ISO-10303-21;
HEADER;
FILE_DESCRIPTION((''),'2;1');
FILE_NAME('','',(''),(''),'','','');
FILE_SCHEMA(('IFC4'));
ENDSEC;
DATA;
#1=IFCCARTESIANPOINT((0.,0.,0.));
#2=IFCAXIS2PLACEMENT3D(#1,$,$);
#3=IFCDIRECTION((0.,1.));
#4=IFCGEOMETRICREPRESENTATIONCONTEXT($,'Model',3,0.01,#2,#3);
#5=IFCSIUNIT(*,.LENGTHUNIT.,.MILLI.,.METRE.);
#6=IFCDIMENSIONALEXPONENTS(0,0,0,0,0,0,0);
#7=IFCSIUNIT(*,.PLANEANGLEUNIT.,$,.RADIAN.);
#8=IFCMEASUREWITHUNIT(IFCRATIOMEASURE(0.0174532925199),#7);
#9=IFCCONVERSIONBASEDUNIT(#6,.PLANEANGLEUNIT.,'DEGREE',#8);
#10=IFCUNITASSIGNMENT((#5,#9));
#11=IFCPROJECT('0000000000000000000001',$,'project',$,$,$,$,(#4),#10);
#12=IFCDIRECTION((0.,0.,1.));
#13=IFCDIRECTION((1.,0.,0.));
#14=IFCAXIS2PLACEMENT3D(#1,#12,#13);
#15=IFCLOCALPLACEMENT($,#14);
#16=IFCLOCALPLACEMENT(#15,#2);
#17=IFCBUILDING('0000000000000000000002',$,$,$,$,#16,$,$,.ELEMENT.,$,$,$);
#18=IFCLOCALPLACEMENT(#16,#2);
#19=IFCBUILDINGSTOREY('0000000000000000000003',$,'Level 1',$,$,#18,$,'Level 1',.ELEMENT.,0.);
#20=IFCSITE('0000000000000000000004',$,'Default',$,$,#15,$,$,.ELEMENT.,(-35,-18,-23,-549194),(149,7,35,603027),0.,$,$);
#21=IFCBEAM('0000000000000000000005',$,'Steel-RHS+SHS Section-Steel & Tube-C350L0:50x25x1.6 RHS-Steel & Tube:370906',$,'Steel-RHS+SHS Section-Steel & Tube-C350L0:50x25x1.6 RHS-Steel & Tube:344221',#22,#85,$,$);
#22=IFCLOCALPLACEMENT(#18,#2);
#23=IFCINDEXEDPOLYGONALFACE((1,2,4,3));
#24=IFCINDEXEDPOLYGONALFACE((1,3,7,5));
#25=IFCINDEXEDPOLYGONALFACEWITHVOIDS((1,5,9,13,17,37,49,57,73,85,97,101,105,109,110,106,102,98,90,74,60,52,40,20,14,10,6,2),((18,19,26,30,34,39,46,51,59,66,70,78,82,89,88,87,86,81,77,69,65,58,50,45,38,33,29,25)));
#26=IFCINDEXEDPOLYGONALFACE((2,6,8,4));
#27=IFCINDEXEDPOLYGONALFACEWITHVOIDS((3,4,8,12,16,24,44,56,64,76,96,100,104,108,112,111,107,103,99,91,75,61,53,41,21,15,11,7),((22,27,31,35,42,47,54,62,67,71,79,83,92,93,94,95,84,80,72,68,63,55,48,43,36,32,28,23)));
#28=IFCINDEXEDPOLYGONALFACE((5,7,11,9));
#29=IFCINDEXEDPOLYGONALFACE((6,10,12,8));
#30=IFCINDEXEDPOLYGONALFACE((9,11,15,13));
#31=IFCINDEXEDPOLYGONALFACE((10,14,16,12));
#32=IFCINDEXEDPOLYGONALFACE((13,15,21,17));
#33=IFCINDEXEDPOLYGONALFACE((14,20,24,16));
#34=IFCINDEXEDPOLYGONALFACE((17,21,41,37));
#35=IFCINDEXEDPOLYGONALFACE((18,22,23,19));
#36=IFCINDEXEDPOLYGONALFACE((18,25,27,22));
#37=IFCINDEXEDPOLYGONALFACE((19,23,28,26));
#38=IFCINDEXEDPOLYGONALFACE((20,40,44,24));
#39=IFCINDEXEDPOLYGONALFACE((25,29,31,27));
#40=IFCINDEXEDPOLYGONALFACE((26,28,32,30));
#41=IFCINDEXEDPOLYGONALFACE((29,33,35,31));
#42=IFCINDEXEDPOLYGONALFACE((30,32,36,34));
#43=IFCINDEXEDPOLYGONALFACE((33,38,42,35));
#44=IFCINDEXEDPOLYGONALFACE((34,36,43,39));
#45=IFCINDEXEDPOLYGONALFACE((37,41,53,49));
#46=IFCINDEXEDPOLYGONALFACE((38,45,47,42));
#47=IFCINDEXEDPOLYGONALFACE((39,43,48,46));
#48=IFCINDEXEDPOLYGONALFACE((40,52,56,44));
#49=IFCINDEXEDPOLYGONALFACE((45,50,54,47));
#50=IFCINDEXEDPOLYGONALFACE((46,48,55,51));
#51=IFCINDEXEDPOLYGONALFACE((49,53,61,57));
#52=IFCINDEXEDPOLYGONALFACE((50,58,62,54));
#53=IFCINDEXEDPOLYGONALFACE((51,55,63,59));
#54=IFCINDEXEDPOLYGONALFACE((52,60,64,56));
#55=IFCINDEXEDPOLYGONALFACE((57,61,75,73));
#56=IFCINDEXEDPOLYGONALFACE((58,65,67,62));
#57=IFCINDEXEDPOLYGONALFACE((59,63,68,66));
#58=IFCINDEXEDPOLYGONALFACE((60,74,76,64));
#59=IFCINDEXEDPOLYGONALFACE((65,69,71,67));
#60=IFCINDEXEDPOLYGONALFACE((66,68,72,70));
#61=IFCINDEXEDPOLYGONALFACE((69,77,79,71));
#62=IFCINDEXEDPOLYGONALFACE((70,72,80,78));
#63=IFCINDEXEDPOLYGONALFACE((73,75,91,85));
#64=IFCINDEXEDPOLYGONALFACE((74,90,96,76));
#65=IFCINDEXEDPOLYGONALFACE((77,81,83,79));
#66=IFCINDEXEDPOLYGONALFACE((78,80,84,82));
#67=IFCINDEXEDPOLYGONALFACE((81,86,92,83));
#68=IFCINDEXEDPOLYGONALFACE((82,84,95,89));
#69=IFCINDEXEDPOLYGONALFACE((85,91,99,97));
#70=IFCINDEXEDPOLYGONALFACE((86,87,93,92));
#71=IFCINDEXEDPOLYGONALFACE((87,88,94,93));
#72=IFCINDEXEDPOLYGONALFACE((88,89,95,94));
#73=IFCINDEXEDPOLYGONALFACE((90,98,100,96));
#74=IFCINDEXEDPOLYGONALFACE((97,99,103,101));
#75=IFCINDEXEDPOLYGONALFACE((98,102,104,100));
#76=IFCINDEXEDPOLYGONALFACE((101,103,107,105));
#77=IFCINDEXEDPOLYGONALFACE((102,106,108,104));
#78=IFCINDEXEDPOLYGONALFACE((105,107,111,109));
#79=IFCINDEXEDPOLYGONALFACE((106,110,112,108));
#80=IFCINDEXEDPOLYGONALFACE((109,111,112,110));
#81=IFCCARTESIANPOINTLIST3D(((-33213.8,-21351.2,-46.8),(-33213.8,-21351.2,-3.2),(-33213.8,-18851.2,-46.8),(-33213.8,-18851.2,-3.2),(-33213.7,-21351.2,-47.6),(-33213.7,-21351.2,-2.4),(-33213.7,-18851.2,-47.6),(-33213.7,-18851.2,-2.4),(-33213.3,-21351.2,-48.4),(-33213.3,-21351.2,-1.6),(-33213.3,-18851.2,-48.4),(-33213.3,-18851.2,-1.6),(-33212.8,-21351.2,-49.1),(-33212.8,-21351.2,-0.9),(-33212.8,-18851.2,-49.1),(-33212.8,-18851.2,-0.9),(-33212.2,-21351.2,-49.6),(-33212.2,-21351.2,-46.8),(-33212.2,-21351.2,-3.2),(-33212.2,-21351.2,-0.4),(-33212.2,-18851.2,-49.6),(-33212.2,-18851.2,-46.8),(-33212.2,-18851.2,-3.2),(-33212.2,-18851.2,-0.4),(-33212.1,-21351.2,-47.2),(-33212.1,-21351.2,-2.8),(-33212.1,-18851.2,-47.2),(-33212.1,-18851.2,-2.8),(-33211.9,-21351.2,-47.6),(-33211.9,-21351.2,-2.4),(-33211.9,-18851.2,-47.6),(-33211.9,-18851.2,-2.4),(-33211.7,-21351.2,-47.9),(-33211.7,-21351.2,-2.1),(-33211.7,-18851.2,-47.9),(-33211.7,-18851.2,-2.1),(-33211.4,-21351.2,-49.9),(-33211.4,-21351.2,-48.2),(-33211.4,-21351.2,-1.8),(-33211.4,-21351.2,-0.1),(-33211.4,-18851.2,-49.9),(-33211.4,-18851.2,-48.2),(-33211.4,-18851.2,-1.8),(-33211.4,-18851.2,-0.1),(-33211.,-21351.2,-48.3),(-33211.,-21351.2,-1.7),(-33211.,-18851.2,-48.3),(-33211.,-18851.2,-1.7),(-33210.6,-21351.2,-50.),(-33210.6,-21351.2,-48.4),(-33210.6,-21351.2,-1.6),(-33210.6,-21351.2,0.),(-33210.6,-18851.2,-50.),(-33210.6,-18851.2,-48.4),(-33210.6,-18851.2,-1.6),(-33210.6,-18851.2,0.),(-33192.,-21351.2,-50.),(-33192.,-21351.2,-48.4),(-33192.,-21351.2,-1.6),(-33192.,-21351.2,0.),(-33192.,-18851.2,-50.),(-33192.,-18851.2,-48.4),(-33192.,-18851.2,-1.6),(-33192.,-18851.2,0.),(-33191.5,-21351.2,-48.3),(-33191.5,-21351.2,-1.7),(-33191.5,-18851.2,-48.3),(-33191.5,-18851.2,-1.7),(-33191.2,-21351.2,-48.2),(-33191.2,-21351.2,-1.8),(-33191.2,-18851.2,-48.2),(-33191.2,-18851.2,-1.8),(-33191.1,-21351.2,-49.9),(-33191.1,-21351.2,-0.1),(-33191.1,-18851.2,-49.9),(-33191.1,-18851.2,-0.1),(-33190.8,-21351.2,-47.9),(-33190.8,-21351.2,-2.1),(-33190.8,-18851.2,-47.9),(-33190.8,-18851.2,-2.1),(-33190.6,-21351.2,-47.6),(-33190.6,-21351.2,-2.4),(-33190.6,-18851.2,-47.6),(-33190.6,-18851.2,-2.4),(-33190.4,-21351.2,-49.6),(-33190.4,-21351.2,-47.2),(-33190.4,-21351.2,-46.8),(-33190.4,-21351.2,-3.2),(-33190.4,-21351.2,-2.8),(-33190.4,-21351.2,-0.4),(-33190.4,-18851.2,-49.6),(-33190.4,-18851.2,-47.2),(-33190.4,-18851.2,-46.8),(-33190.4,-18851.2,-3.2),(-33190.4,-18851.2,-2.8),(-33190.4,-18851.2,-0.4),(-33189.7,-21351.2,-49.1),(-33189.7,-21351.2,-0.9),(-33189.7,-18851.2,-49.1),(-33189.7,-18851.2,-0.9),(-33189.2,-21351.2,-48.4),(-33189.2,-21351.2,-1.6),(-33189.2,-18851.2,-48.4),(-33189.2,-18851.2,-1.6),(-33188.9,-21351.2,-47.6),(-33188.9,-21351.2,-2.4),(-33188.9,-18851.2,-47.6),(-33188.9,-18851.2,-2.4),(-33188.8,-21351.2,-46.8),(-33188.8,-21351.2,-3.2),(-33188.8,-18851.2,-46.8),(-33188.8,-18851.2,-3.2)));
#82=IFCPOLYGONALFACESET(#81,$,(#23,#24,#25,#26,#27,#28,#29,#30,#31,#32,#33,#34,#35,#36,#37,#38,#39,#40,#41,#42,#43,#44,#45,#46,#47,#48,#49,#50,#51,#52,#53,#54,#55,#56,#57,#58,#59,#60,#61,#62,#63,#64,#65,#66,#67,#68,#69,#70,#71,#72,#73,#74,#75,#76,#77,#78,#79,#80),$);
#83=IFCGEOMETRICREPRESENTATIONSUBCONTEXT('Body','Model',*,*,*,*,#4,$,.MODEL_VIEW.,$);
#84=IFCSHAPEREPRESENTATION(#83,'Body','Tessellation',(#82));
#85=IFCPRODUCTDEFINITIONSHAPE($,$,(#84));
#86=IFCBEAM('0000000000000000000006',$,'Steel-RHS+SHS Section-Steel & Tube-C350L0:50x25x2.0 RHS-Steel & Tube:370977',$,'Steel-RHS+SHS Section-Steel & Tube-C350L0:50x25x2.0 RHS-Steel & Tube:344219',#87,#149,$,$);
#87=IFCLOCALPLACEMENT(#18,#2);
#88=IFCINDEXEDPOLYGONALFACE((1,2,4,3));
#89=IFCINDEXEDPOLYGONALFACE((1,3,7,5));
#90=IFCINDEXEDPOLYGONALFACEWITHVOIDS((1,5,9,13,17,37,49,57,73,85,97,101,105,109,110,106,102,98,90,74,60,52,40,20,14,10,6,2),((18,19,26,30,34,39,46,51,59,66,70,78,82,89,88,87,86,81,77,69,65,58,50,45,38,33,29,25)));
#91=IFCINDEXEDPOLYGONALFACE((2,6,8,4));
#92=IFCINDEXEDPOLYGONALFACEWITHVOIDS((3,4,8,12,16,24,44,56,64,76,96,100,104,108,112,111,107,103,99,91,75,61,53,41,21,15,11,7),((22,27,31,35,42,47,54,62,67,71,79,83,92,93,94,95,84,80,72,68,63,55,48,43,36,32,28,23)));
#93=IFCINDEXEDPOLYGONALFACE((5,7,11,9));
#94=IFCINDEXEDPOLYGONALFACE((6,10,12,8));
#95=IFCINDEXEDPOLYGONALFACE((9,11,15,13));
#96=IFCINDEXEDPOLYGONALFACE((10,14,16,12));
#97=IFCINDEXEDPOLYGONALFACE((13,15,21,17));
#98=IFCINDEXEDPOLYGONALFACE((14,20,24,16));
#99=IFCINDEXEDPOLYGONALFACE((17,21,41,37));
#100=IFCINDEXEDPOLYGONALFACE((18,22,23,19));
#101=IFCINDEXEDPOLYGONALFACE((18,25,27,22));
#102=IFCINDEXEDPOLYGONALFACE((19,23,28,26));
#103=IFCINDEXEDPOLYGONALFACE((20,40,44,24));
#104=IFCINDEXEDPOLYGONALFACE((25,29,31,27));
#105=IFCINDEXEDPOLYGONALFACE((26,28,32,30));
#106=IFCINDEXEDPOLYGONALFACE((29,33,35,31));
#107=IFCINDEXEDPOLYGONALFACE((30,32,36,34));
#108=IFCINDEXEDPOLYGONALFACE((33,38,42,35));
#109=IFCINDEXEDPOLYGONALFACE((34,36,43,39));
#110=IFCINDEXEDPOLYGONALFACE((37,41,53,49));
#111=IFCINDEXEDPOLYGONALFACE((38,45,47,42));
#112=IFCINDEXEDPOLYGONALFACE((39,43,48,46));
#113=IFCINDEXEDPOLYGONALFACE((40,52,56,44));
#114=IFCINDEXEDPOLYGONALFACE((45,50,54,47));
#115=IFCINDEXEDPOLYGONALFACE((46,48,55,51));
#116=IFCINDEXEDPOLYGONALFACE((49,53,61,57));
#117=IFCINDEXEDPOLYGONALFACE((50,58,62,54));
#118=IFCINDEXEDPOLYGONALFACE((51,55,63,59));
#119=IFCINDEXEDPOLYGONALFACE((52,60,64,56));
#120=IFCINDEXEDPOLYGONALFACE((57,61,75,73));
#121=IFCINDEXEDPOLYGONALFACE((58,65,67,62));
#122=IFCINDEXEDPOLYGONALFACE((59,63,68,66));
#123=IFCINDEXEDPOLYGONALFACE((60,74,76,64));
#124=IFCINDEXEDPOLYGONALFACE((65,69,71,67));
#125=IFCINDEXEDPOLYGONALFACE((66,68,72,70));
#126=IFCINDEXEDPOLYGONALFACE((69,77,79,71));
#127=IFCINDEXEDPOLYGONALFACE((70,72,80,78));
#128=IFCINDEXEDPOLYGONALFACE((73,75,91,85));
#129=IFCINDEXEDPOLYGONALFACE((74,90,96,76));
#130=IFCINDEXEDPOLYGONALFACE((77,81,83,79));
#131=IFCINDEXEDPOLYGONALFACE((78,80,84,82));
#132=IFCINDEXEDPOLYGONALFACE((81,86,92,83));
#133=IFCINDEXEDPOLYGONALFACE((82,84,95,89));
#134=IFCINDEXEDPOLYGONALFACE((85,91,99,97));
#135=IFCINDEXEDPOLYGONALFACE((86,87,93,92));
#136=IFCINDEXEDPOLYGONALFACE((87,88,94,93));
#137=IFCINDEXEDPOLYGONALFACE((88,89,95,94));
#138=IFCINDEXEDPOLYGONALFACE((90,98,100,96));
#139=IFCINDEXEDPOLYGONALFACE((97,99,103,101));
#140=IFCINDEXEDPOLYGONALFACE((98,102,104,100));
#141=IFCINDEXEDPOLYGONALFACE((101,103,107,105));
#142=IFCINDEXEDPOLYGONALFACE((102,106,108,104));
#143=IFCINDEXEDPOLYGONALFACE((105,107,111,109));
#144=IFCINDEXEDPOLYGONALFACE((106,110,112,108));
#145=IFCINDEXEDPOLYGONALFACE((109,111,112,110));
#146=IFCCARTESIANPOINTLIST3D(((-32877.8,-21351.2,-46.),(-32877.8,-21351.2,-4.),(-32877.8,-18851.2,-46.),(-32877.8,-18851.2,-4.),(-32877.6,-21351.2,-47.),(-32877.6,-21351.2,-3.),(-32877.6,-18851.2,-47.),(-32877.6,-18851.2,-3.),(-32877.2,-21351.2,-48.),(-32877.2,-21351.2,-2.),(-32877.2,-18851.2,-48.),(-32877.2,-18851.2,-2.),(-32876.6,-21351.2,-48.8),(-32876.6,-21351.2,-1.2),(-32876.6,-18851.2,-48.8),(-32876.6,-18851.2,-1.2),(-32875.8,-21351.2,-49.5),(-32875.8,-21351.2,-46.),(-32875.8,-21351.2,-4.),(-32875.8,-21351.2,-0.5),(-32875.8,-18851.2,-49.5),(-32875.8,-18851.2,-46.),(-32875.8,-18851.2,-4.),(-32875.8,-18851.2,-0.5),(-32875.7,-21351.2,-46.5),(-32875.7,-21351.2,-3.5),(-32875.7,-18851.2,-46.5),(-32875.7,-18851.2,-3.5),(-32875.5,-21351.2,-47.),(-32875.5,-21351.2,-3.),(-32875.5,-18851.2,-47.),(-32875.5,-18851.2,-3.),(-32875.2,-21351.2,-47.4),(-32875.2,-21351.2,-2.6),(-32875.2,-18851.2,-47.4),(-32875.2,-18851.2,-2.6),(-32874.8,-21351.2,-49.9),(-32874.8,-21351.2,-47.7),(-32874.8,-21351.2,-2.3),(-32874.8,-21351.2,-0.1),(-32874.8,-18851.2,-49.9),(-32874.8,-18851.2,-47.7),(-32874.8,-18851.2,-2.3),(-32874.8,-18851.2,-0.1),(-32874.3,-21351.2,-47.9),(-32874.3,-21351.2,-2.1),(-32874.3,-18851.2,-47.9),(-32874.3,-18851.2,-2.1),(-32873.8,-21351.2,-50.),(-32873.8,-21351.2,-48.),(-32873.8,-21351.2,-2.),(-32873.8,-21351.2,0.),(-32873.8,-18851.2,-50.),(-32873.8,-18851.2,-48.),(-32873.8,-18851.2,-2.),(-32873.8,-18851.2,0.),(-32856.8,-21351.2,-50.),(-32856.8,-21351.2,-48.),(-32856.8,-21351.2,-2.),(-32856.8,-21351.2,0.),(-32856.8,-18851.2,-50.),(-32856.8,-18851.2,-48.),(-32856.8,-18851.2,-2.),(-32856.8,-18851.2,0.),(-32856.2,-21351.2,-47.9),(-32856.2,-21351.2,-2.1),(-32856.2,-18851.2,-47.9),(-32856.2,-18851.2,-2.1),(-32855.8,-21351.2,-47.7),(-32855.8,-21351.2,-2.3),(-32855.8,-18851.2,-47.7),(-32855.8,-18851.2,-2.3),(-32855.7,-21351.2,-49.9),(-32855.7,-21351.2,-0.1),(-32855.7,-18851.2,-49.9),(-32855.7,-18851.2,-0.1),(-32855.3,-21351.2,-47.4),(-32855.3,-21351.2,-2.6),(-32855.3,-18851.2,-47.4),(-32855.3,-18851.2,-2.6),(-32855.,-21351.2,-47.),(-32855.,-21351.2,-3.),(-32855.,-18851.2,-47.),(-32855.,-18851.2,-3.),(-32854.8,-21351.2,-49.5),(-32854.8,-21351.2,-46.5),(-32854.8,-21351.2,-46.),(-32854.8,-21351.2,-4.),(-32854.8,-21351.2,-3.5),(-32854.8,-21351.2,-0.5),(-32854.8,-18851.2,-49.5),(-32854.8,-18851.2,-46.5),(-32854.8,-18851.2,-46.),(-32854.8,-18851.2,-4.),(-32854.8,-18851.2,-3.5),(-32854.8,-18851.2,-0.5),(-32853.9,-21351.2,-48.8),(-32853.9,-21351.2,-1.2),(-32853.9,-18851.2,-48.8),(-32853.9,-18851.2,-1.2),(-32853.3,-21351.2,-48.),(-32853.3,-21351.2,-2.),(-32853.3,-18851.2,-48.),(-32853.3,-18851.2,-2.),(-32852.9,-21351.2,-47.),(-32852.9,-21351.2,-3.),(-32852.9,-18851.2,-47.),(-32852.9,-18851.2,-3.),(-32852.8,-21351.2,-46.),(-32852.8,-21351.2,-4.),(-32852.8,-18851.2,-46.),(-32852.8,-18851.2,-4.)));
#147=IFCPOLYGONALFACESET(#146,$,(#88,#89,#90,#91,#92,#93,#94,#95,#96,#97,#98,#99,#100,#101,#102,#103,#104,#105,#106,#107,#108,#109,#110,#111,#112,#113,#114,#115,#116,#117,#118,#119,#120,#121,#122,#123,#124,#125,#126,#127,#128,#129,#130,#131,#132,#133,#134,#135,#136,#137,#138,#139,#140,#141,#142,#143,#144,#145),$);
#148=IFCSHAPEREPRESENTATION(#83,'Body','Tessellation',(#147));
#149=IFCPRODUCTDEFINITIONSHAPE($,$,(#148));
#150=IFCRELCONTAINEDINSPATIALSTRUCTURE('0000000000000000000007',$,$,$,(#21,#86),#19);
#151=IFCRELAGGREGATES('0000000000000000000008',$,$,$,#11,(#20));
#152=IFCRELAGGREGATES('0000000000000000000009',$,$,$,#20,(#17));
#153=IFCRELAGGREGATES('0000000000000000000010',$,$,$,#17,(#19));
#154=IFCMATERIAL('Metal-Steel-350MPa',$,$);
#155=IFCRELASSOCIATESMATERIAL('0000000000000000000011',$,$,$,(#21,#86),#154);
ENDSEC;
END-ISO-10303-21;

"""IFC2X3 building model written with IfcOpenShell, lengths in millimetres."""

from ifc_helpers import new_model, entity, si_unit, converted_unit, direction, frame, frame_2d, origin, origin_with_axes, place, context, subcontext, project, spatial, polyline, circle_curve, parameter, trimmed, segment, composite_curve, outline, extrude, material, element, save


model = new_model("IFC2X3")

# Units and contexts
model_context = context("Model", 3, precision=0.01, world=origin(), true_north=direction((0.0, 1.0)))
body_context = subcontext(model_context, "Body", "Model", "MODEL_VIEW")
ifc_project = project(units=[si_unit("LENGTHUNIT", "METRE", prefix="MILLI"), converted_unit("PLANEANGLEUNIT", "DEGREE", entity("IfcRatioMeasure", 0.0174532925199), si_unit("PLANEANGLEUNIT", "RADIAN"), dimensions=[0, 0, 0, 0, 0, 0, 0])], contexts=[model_context])

# Site, building, storey
site_placement = place(None, origin_with_axes())
site = spatial("IfcSite", under=ifc_project, at=site_placement, Name="Default", CompositionType="ELEMENT", RefLatitude=(-35, -18, -23, -549194), RefLongitude=(149, 7, 35, 603027), RefElevation=0.0)
building_placement = place(site_placement, origin())
building = spatial("IfcBuilding", under=site, at=building_placement, CompositionType="ELEMENT")
storey_placement = place(building_placement, origin())
storey = spatial("IfcBuildingStorey", under=building, at=storey_placement, Name="Level 1", LongName="Level 1", CompositionType="ELEMENT", Elevation=0.0)

# Beams
ifc_material = material(Name="Metal-Steel-350MPa")
beam_1_placement = place(storey_placement, frame((-33201.3, -18851.2, 0.0), z_axis=(0.0, 0.0, 1.0), x_axis=(0.0, -1.0, 0.0)))
element("IfcBeam", 1, at=beam_1_placement, inside=storey, material=ifc_material, Name="Steel-RHS+SHS Section-Steel & Tube-C350L0:50x25x1.6 RHS-Steel & Tube:370906", ObjectType="Steel-RHS+SHS Section-Steel & Tube-C350L0:50x25x1.6 RHS-Steel & Tube:344221", context=body_context, shape_type="SweptSolid", body=[
    extrude(outline(composite_curve([segment(trimmed(circle_curve(frame_2d((-9.3, -21.8), x_axis=(1.0, 0.0)), 3.2), [parameter(180.0)], [parameter(270.0)], True, "PARAMETER"), True, "CONTINUOUS"), segment(polyline([(-9.3, -25.0), (9.3, -25.0)]), True, "CONTINUOUS"), segment(trimmed(circle_curve(frame_2d((9.3, -21.8), x_axis=(1.0, 0.0)), 3.2), [parameter(270.0)], [parameter(0.0)], True, "PARAMETER"), True, "CONTINUOUS"), segment(polyline([(12.5, -21.8), (12.5, 21.8)]), True, "CONTINUOUS"), segment(trimmed(circle_curve(frame_2d((9.3, 21.8), x_axis=(1.0, 0.0)), 3.2), [parameter(0.0)], [parameter(90.0)], True, "PARAMETER"), True, "CONTINUOUS"), segment(polyline([(9.3, 25.0), (-9.3, 25.0)]), True, "CONTINUOUS"), segment(trimmed(circle_curve(frame_2d((-9.3, 21.8), x_axis=(1.0, 0.0)), 3.2), [parameter(90.0)], [parameter(180.0)], True, "PARAMETER"), True, "CONTINUOUS"), segment(polyline([(-12.5, 21.8), (-12.5, -21.8)]), True, "CONTINUOUS")], self_intersect=False), holes=[composite_curve([segment(polyline([(9.3, -23.4), (-9.3, -23.4)]), True, "CONTINUOUS"), segment(trimmed(circle_curve(frame_2d((-9.3, -21.8), x_axis=(1.0, 0.0)), 1.6), [parameter(180.0)], [parameter(270.0)], True, "PARAMETER"), False, "CONTINUOUS"), segment(polyline([(-10.9, -21.8), (-10.9, 21.8)]), True, "CONTINUOUS"), segment(trimmed(circle_curve(frame_2d((-9.3, 21.8), x_axis=(1.0, 0.0)), 1.6), [parameter(90.0)], [parameter(180.0)], True, "PARAMETER"), False, "CONTINUOUS"), segment(polyline([(-9.3, 23.4), (9.3, 23.4)]), True, "CONTINUOUS"), segment(trimmed(circle_curve(frame_2d((9.3, 21.8), x_axis=(1.0, 0.0)), 1.6), [parameter(360.0)], [parameter(90.0)], True, "PARAMETER"), False, "CONTINUOUS"), segment(polyline([(10.9, 21.8), (10.9, -21.8)]), True, "CONTINUOUS"), segment(trimmed(circle_curve(frame_2d((9.3, -21.8), x_axis=(1.0, 0.0)), 1.6), [parameter(270.0)], [parameter(0.0)], True, "PARAMETER"), False, "CONTINUOUS")], self_intersect=False)]), frame((0.0, 0.0, -25.0), z_axis=(1.0, 0.0, 0.0), x_axis=(0.0, -1.0, 0.0)), (0.0, 0.0, 1.0), 2500.0),
])
beam_2_placement = place(storey_placement, frame((-32865.3, -18851.2, 0.0), z_axis=(0.0, 0.0, 1.0), x_axis=(0.0, -1.0, 0.0)))
element("IfcBeam", 2, at=beam_2_placement, inside=storey, material=ifc_material, Name="Steel-RHS+SHS Section-Steel & Tube-C350L0:50x25x2.0 RHS-Steel & Tube:370977", ObjectType="Steel-RHS+SHS Section-Steel & Tube-C350L0:50x25x2.0 RHS-Steel & Tube:344219", context=body_context, shape_type="SweptSolid", body=[
    extrude(outline(composite_curve([segment(trimmed(circle_curve(frame_2d((-8.5, -21.0), x_axis=(1.0, 0.0)), 4.0), [parameter(180.0)], [parameter(270.0)], True, "PARAMETER"), True, "CONTINUOUS"), segment(polyline([(-8.5, -25.0), (8.5, -25.0)]), True, "CONTINUOUS"), segment(trimmed(circle_curve(frame_2d((8.5, -21.0), x_axis=(1.0, 0.0)), 4.0), [parameter(270.0)], [parameter(0.0)], True, "PARAMETER"), True, "CONTINUOUS"), segment(polyline([(12.5, -21.0), (12.5, 21.0)]), True, "CONTINUOUS"), segment(trimmed(circle_curve(frame_2d((8.5, 21.0), x_axis=(1.0, 0.0)), 4.0), [parameter(0.0)], [parameter(90.0)], True, "PARAMETER"), True, "CONTINUOUS"), segment(polyline([(8.5, 25.0), (-8.5, 25.0)]), True, "CONTINUOUS"), segment(trimmed(circle_curve(frame_2d((-8.5, 21.0), x_axis=(1.0, 0.0)), 4.0), [parameter(90.0)], [parameter(180.0)], True, "PARAMETER"), True, "CONTINUOUS"), segment(polyline([(-12.5, 21.0), (-12.5, -21.0)]), True, "CONTINUOUS")], self_intersect=False), holes=[composite_curve([segment(polyline([(8.5, -23.0), (-8.5, -23.0)]), True, "CONTINUOUS"), segment(trimmed(circle_curve(frame_2d((-8.5, -21.0), x_axis=(1.0, 0.0)), 2.0), [parameter(180.0)], [parameter(270.0)], True, "PARAMETER"), False, "CONTINUOUS"), segment(polyline([(-10.5, -21.0), (-10.5, 21.0)]), True, "CONTINUOUS"), segment(trimmed(circle_curve(frame_2d((-8.5, 21.0), x_axis=(1.0, 0.0)), 2.0), [parameter(90.0)], [parameter(180.0)], True, "PARAMETER"), False, "CONTINUOUS"), segment(polyline([(-8.5, 23.0), (8.5, 23.0)]), True, "CONTINUOUS"), segment(trimmed(circle_curve(frame_2d((8.5, 21.0), x_axis=(1.0, 0.0)), 2.0), [parameter(360.0)], [parameter(90.0)], True, "PARAMETER"), False, "CONTINUOUS"), segment(polyline([(10.5, 21.0), (10.5, -21.0)]), True, "CONTINUOUS"), segment(trimmed(circle_curve(frame_2d((8.5, -21.0), x_axis=(1.0, 0.0)), 2.0), [parameter(270.0)], [parameter(0.0)], True, "PARAMETER"), False, "CONTINUOUS")], self_intersect=False)]), frame((0.0, 0.0, -25.0), z_axis=(1.0, 0.0, 0.0), x_axis=(0.0, -1.0, 0.0)), (0.0, 0.0, 1.0), 2500.0),
])

save(model, "model.ifc")
